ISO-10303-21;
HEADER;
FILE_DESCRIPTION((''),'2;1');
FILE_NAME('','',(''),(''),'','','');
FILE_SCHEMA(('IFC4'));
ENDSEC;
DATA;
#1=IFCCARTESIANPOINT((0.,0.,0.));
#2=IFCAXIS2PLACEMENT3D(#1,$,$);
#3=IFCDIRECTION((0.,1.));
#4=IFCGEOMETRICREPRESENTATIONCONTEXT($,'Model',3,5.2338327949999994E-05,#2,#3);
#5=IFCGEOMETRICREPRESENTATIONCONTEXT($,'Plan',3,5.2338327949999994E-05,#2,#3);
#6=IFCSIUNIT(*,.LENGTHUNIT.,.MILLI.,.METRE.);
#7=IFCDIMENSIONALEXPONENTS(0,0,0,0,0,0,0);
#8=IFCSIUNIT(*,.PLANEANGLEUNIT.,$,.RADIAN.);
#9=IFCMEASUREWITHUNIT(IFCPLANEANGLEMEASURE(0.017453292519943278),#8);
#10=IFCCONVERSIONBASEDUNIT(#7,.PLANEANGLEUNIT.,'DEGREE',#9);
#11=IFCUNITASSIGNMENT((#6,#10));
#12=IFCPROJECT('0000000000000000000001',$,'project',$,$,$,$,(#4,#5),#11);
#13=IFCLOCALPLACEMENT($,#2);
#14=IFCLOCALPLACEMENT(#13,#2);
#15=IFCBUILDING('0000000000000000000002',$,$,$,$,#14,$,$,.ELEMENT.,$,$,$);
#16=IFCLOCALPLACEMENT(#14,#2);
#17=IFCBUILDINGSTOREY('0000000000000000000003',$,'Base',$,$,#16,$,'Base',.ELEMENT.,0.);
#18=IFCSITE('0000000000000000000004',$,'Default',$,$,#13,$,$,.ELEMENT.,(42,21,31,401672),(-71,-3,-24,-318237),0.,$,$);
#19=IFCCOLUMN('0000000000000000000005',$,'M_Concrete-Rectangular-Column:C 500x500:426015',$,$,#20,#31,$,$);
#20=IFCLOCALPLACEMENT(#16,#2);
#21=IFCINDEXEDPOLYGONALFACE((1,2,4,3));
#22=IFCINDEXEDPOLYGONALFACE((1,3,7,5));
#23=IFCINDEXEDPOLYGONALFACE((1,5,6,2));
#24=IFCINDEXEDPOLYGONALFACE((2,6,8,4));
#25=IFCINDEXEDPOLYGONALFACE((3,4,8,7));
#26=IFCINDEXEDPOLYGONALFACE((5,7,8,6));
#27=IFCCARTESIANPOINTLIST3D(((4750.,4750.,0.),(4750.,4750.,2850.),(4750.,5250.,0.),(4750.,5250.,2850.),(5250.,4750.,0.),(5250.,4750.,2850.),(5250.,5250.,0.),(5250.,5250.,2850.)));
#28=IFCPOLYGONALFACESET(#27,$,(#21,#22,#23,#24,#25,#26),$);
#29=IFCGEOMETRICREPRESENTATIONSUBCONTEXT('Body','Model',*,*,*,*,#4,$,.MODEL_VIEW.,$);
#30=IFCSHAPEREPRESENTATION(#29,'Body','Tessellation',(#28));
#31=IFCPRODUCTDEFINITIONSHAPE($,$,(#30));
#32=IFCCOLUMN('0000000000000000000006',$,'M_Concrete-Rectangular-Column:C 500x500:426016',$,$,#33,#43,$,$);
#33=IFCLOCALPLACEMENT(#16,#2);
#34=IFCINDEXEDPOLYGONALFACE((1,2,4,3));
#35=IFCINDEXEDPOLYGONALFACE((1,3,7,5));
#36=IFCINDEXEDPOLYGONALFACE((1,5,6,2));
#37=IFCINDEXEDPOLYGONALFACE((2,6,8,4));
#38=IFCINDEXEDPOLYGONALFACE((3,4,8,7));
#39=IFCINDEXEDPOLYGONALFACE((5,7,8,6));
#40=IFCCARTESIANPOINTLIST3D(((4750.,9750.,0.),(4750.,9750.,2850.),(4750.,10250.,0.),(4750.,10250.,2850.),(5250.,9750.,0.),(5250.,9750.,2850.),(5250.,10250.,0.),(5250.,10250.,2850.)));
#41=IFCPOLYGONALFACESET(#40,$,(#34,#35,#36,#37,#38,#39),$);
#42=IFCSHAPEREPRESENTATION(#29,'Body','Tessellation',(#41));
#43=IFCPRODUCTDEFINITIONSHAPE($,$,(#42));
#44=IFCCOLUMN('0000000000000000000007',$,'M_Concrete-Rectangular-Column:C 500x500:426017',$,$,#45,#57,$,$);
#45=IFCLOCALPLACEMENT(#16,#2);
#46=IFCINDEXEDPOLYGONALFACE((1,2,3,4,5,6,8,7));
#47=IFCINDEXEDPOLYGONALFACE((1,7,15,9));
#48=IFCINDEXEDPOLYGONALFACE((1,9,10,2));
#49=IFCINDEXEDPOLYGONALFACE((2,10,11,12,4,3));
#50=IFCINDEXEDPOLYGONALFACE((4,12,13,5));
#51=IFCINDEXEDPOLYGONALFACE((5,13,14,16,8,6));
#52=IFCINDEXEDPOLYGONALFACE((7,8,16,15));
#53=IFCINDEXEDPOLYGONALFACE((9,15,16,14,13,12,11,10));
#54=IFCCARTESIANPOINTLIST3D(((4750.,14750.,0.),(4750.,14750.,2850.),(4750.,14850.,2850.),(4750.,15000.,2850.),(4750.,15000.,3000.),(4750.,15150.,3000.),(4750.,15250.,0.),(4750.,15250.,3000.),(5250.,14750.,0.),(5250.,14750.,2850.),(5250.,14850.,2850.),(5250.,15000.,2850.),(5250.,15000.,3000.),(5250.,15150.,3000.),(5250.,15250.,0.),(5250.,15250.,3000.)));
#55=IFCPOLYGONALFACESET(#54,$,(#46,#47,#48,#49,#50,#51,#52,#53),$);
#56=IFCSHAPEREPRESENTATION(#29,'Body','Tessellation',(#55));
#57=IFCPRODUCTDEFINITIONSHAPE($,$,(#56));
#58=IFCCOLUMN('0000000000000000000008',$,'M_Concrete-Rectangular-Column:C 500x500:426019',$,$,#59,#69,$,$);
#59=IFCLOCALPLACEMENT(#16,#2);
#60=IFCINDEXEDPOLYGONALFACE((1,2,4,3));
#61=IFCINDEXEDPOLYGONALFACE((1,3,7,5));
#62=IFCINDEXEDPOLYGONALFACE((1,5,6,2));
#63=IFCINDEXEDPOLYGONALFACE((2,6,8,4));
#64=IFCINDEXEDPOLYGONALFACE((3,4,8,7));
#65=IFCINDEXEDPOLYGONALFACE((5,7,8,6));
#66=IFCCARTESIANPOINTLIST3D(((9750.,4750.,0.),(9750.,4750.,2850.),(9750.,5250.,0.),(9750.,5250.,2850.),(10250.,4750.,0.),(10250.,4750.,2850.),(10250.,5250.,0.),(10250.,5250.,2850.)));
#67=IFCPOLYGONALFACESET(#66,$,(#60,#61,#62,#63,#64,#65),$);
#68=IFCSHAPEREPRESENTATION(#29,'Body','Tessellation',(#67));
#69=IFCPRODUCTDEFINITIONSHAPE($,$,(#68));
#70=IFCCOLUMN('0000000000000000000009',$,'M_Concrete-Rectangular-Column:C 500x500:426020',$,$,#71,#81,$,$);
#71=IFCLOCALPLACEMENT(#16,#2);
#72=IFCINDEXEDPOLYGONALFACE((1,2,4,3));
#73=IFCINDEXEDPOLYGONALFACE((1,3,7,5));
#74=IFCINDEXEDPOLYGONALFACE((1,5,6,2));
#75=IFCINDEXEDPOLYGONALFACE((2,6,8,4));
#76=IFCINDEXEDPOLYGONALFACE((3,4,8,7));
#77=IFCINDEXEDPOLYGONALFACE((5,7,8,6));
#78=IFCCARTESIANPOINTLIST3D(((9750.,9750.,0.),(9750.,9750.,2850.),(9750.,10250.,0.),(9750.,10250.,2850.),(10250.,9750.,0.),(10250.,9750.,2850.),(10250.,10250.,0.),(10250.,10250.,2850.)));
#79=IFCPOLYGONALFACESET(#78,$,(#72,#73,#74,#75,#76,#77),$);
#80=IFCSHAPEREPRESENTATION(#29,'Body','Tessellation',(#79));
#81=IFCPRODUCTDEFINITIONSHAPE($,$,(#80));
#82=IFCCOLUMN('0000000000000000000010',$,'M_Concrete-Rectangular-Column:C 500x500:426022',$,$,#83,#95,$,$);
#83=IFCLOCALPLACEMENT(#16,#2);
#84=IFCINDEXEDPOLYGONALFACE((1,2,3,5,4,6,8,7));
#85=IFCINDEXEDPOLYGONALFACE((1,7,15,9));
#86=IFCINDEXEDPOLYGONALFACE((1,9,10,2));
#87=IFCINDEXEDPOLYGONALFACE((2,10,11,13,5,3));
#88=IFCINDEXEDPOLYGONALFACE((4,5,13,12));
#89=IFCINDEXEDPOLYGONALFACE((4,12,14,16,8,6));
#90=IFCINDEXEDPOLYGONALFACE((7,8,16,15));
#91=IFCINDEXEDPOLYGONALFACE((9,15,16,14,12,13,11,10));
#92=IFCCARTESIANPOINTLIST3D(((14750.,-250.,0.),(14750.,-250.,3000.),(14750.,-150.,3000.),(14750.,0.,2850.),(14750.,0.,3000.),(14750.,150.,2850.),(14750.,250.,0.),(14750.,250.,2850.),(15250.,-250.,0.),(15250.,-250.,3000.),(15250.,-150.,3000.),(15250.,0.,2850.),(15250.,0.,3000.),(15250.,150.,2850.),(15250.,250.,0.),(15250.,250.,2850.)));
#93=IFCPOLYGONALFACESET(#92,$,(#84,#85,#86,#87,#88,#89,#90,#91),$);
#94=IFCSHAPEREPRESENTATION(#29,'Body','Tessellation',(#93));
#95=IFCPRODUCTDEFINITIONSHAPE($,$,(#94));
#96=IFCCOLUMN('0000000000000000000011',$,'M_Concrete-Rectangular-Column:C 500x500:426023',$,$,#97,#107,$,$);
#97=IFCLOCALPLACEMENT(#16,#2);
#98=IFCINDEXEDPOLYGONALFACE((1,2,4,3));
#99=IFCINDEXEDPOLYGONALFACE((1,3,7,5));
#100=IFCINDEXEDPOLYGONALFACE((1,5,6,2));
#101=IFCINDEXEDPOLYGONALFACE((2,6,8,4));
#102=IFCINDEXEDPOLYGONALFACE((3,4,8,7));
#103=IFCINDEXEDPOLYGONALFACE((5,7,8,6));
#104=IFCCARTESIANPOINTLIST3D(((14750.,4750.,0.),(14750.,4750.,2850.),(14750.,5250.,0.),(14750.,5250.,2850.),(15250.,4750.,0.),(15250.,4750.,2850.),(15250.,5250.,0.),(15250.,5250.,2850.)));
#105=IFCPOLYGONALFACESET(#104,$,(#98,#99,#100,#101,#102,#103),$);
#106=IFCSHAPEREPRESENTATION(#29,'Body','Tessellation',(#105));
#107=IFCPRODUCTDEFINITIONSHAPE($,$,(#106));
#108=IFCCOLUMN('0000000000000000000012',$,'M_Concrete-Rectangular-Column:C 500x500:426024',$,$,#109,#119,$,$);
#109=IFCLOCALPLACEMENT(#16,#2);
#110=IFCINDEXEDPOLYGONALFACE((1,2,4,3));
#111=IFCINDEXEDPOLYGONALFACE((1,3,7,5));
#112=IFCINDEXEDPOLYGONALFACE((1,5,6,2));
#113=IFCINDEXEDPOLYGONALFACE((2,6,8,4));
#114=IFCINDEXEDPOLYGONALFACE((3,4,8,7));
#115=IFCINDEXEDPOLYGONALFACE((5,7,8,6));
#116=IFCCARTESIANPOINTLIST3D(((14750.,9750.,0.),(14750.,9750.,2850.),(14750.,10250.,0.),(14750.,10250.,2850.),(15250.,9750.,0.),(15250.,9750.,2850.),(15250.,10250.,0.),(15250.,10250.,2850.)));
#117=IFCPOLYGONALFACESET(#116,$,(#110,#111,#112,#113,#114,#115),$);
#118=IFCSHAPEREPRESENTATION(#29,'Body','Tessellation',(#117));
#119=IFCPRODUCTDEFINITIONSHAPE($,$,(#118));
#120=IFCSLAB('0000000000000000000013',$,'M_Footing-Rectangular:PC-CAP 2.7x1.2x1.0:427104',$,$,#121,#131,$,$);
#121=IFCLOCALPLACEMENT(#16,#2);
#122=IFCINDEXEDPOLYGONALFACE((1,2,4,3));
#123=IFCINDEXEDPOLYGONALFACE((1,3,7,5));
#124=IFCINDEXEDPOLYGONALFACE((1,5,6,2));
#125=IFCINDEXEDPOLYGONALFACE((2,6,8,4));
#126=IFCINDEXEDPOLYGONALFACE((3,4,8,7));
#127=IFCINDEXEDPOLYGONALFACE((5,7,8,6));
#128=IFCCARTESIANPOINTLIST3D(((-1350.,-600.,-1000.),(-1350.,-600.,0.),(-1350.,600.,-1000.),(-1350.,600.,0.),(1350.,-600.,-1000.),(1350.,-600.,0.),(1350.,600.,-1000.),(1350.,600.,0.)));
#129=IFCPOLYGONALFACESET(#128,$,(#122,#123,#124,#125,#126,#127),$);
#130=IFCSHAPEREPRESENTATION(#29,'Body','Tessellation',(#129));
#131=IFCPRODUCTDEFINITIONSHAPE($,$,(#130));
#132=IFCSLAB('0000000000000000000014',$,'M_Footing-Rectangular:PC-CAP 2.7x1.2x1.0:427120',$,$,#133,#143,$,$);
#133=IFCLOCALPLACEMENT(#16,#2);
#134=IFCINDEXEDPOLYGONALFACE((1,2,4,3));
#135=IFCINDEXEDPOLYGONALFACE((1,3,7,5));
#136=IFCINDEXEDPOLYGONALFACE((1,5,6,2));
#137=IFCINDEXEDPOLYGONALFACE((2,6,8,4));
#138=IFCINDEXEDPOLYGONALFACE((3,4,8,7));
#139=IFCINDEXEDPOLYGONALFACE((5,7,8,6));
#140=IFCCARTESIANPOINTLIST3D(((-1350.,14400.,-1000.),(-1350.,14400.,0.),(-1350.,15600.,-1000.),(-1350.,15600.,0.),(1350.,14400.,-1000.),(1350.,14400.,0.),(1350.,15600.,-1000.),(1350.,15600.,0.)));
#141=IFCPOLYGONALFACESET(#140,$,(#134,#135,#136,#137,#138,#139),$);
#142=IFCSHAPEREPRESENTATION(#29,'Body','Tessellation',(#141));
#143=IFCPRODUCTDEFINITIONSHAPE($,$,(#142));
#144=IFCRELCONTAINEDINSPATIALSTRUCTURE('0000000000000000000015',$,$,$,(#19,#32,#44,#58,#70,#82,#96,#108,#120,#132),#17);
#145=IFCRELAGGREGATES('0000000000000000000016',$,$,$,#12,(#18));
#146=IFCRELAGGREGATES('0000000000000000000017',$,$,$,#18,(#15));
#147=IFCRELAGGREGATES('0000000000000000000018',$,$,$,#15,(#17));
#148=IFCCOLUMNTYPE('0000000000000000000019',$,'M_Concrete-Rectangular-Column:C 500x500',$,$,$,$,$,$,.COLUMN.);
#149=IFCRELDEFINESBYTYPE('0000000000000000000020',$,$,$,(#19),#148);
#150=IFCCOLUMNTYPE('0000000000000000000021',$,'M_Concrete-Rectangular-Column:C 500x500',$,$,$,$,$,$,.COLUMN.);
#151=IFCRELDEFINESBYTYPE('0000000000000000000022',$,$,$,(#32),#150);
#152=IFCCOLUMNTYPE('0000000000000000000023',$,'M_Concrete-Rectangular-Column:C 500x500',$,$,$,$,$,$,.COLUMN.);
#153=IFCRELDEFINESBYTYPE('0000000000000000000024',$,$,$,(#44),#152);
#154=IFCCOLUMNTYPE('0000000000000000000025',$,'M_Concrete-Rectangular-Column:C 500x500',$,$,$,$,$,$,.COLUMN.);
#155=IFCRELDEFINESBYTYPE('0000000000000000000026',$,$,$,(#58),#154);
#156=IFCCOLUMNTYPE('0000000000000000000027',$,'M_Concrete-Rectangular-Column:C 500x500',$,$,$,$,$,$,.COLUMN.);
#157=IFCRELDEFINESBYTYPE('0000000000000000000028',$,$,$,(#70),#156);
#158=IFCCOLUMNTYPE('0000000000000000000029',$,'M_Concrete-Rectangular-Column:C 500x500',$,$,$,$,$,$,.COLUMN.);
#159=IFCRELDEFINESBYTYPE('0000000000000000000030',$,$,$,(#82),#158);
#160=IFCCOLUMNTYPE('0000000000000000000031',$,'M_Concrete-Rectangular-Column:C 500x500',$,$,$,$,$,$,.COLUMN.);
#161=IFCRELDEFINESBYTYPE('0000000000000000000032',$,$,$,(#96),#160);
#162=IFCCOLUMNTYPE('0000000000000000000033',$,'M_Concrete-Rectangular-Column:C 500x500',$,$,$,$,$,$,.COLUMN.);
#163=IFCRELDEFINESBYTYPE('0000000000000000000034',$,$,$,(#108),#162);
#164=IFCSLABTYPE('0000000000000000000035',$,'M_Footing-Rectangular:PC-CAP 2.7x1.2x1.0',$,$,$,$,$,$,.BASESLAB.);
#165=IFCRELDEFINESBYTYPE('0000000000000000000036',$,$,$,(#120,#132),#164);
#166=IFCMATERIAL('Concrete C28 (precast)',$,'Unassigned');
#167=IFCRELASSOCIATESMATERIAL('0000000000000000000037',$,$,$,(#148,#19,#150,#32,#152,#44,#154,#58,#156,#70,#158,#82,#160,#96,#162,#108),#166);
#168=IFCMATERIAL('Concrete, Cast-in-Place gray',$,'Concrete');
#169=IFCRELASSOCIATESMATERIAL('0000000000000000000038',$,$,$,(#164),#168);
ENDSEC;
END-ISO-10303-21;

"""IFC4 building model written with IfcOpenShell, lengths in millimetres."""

from ifc_helpers import new_model, entity, si_unit, converted_unit, direction, frame, origin, place, context, subcontext, project, spatial, indexed_curve, outline, extrude, source, transform, mapped, material, type_object, type_shapes, element, save


model = new_model("IFC4")

# Units and contexts
model_context = context("Model", 3, precision=5.2338327949999994e-05, world=origin(), true_north=direction((0.0, 1.0)))
plan_context = context("Plan", 3, precision=5.2338327949999994e-05, world=origin(), true_north=direction((0.0, 1.0)))
body_context = subcontext(model_context, "Body", "Model", "MODEL_VIEW")
ifc_project = project(units=[si_unit("LENGTHUNIT", "METRE", prefix="MILLI"), converted_unit("PLANEANGLEUNIT", "DEGREE", entity("IfcPlaneAngleMeasure", 0.017453292519943278), si_unit("PLANEANGLEUNIT", "RADIAN"), dimensions=[0, 0, 0, 0, 0, 0, 0])], contexts=[model_context, plan_context])

# Site, building, storey
site_placement = place(None, origin())
site = spatial("IfcSite", under=ifc_project, at=site_placement, Name="Default", CompositionType="ELEMENT", RefLatitude=(42, 21, 31, 401672), RefLongitude=(-71, -3, -24, -318237), RefElevation=0.0)
building_placement = place(site_placement, origin())
building = spatial("IfcBuilding", under=site, at=building_placement, CompositionType="ELEMENT")
storey_placement = place(building_placement, origin())
storey = spatial("IfcBuildingStorey", under=building, at=storey_placement, Name="Base", LongName="Base", CompositionType="ELEMENT", Elevation=0.0)

# Columns
ifc_material_1 = material(Name="Concrete C28 (precast)", Category="Unassigned")
column_type_1 = type_object("IfcColumnType", Name="M_Concrete-Rectangular-Column:C 500x500", PredefinedType="COLUMN", material=ifc_material_1)
shared_shape_1 = source(origin(), body_context, "Body", "SweptSolid", [
    extrude(outline(indexed_curve([(-250.0, -250.0), (250.0, -250.0), (250.0, 250.0), (-250.0, 250.0), (-250.0, -250.0)], self_intersect=False)), frame((5000.0, 5000.0, 0.0), z_axis=(0.0, 0.0, 1.0), x_axis=(-1.0, 0.0, 0.0)), (0.0, 0.0, 1.0), 2850.0),
])
type_shapes(column_type_1, [shared_shape_1])
column_1_placement = place(storey_placement, origin())
element("IfcColumn", 1, at=column_1_placement, inside=storey, type_object=column_type_1, material=ifc_material_1, Name="M_Concrete-Rectangular-Column:C 500x500:426015", context=body_context, shape_type="MappedRepresentation", body=[
    mapped(shared_shape_1, transform((0.0, 0.0, 0.0), scale=1.0)),
])
column_type_2 = type_object("IfcColumnType", Name="M_Concrete-Rectangular-Column:C 500x500", PredefinedType="COLUMN", material=ifc_material_1)
shared_shape_2 = source(origin(), body_context, "Body", "SweptSolid", [
    extrude(outline(indexed_curve([(-250.0, -250.0), (250.0, -250.0), (250.0, 250.0), (-250.0, 250.0), (-250.0, -250.0)], self_intersect=False)), frame((5000.0, 10000.0, 0.0), z_axis=(0.0, 0.0, 1.0), x_axis=(-1.0, 0.0, 0.0)), (0.0, 0.0, 1.0), 2850.0),
])
type_shapes(column_type_2, [shared_shape_2])
column_2_placement = place(storey_placement, origin())
element("IfcColumn", 2, at=column_2_placement, inside=storey, type_object=column_type_2, material=ifc_material_1, Name="M_Concrete-Rectangular-Column:C 500x500:426016", context=body_context, shape_type="MappedRepresentation", body=[
    mapped(shared_shape_2, transform((0.0, 0.0, 0.0), scale=1.0)),
])
column_type_3 = type_object("IfcColumnType", Name="M_Concrete-Rectangular-Column:C 500x500", PredefinedType="COLUMN", material=ifc_material_1)
shared_shape_3 = source(origin(), body_context, "Body", "SweptSolid", [
    extrude(outline(indexed_curve([(-2193.7, -250.0), (806.2, -250.0), (806.2, -150.0), (806.2, 0.0), (656.2, 0.0), (656.2, 150.0), (656.2, 250.0), (-2193.7, 250.0), (-2193.7, -250.0)], self_intersect=False)), frame((4750.0, 15000.0, 2193.7), z_axis=(1.0, 0.0, 0.0), x_axis=(0.0, 0.0, 1.0)), (0.0, 0.0, 1.0), 500.0),
])
type_shapes(column_type_3, [shared_shape_3])
column_3_placement = place(storey_placement, origin())
element("IfcColumn", 3, at=column_3_placement, inside=storey, type_object=column_type_3, material=ifc_material_1, Name="M_Concrete-Rectangular-Column:C 500x500:426017", context=body_context, shape_type="MappedRepresentation", body=[
    mapped(shared_shape_3, transform((0.0, 0.0, 0.0), scale=1.0)),
])
column_type_4 = type_object("IfcColumnType", Name="M_Concrete-Rectangular-Column:C 500x500", PredefinedType="COLUMN", material=ifc_material_1)
shared_shape_4 = source(origin(), body_context, "Body", "SweptSolid", [
    extrude(outline(indexed_curve([(-250.0, -250.0), (250.0, -250.0), (250.0, 250.0), (-250.0, 250.0), (-250.0, -250.0)], self_intersect=False)), frame((10000.0, 5000.0, 0.0), z_axis=(0.0, 0.0, 1.0), x_axis=(-1.0, 0.0, 0.0)), (0.0, 0.0, 1.0), 2850.0),
])
type_shapes(column_type_4, [shared_shape_4])
column_4_placement = place(storey_placement, origin())
element("IfcColumn", 4, at=column_4_placement, inside=storey, type_object=column_type_4, material=ifc_material_1, Name="M_Concrete-Rectangular-Column:C 500x500:426019", context=body_context, shape_type="MappedRepresentation", body=[
    mapped(shared_shape_4, transform((0.0, 0.0, 0.0), scale=1.0)),
])
column_type_5 = type_object("IfcColumnType", Name="M_Concrete-Rectangular-Column:C 500x500", PredefinedType="COLUMN", material=ifc_material_1)
shared_shape_5 = source(origin(), body_context, "Body", "SweptSolid", [
    extrude(outline(indexed_curve([(-250.0, -250.0), (250.0, -250.0), (250.0, 250.0), (-250.0, 250.0), (-250.0, -250.0)], self_intersect=False)), frame((10000.0, 10000.0, 0.0), z_axis=(0.0, 0.0, 1.0), x_axis=(-1.0, 0.0, 0.0)), (0.0, 0.0, 1.0), 2850.0),
])
type_shapes(column_type_5, [shared_shape_5])
column_5_placement = place(storey_placement, origin())
element("IfcColumn", 5, at=column_5_placement, inside=storey, type_object=column_type_5, material=ifc_material_1, Name="M_Concrete-Rectangular-Column:C 500x500:426020", context=body_context, shape_type="MappedRepresentation", body=[
    mapped(shared_shape_5, transform((0.0, 0.0, 0.0), scale=1.0)),
])
column_type_6 = type_object("IfcColumnType", Name="M_Concrete-Rectangular-Column:C 500x500", PredefinedType="COLUMN", material=ifc_material_1)
shared_shape_6 = source(origin(), body_context, "Body", "SweptSolid", [
    extrude(outline(indexed_curve([(-2193.8, -250.0), (656.2, -250.0), (656.2, -150.0), (656.2, 0.0), (806.2, 0.0), (806.2, 150.0), (806.2, 250.0), (-2193.8, 250.0), (-2193.8, -250.0)], self_intersect=False)), frame((14750.0, 0.0, 2193.8), z_axis=(1.0, 0.0, 0.0), x_axis=(0.0, 0.0, 1.0)), (0.0, 0.0, 1.0), 500.0),
])
type_shapes(column_type_6, [shared_shape_6])
column_6_placement = place(storey_placement, origin())
element("IfcColumn", 6, at=column_6_placement, inside=storey, type_object=column_type_6, material=ifc_material_1, Name="M_Concrete-Rectangular-Column:C 500x500:426022", context=body_context, shape_type="MappedRepresentation", body=[
    mapped(shared_shape_6, transform((0.0, 0.0, 0.0), scale=1.0)),
])
column_type_7 = type_object("IfcColumnType", Name="M_Concrete-Rectangular-Column:C 500x500", PredefinedType="COLUMN", material=ifc_material_1)
shared_shape_7 = source(origin(), body_context, "Body", "SweptSolid", [
    extrude(outline(indexed_curve([(-250.0, -250.0), (250.0, -250.0), (250.0, 250.0), (-250.0, 250.0), (-250.0, -250.0)], self_intersect=False)), frame((15000.0, 5000.0, 0.0), z_axis=(0.0, 0.0, 1.0), x_axis=(-1.0, 0.0, 0.0)), (0.0, 0.0, 1.0), 2850.0),
])
type_shapes(column_type_7, [shared_shape_7])
column_7_placement = place(storey_placement, origin())
element("IfcColumn", 7, at=column_7_placement, inside=storey, type_object=column_type_7, material=ifc_material_1, Name="M_Concrete-Rectangular-Column:C 500x500:426023", context=body_context, shape_type="MappedRepresentation", body=[
    mapped(shared_shape_7, transform((0.0, 0.0, 0.0), scale=1.0)),
])
column_type_8 = type_object("IfcColumnType", Name="M_Concrete-Rectangular-Column:C 500x500", PredefinedType="COLUMN", material=ifc_material_1)
shared_shape_8 = source(origin(), body_context, "Body", "SweptSolid", [
    extrude(outline(indexed_curve([(-250.0, -250.0), (250.0, -250.0), (250.0, 250.0), (-250.0, 250.0), (-250.0, -250.0)], self_intersect=False)), frame((15000.0, 10000.0, 0.0), z_axis=(0.0, 0.0, 1.0), x_axis=(-1.0, 0.0, 0.0)), (0.0, 0.0, 1.0), 2850.0),
])
type_shapes(column_type_8, [shared_shape_8])
column_8_placement = place(storey_placement, origin())
element("IfcColumn", 8, at=column_8_placement, inside=storey, type_object=column_type_8, material=ifc_material_1, Name="M_Concrete-Rectangular-Column:C 500x500:426024", context=body_context, shape_type="MappedRepresentation", body=[
    mapped(shared_shape_8, transform((0.0, 0.0, 0.0), scale=1.0)),
])

# Slabs
ifc_material_2 = material(Name="Concrete, Cast-in-Place gray", Category="Concrete")
slab_type_1 = type_object("IfcSlabType", Name="M_Footing-Rectangular:PC-CAP 2.7x1.2x1.0", PredefinedType="BASESLAB", material=ifc_material_2)
slab_1_placement = place(storey_placement, origin())
element("IfcSlab", 9, at=slab_1_placement, inside=storey, type_object=slab_type_1, Name="M_Footing-Rectangular:PC-CAP 2.7x1.2x1.0:427104", context=body_context, shape_type="SweptSolid", body=[
    extrude(outline(indexed_curve([(-1350.0, -600.0), (1350.0, -600.0), (1350.0, 600.0), (-1350.0, 600.0), (-1350.0, -600.0)], self_intersect=False)), frame((0.0, 0.0, -1000.0), z_axis=(0.0, 0.0, 1.0), x_axis=(-1.0, 0.0, 0.0)), (0.0, 0.0, 1.0), 1000.0),
])
slab_2_placement = place(storey_placement, origin())
element("IfcSlab", 10, at=slab_2_placement, inside=storey, type_object=slab_type_1, Name="M_Footing-Rectangular:PC-CAP 2.7x1.2x1.0:427120", context=body_context, shape_type="SweptSolid", body=[
    extrude(outline(indexed_curve([(-1350.0, -600.0), (1350.0, -600.0), (1350.0, 600.0), (-1350.0, 600.0), (-1350.0, -600.0)], self_intersect=False)), frame((0.0, 15000.0, -1000.0), z_axis=(0.0, 0.0, 1.0), x_axis=(-1.0, 0.0, 0.0)), (0.0, 0.0, 1.0), 1000.0),
])

save(model, "model.ifc")
